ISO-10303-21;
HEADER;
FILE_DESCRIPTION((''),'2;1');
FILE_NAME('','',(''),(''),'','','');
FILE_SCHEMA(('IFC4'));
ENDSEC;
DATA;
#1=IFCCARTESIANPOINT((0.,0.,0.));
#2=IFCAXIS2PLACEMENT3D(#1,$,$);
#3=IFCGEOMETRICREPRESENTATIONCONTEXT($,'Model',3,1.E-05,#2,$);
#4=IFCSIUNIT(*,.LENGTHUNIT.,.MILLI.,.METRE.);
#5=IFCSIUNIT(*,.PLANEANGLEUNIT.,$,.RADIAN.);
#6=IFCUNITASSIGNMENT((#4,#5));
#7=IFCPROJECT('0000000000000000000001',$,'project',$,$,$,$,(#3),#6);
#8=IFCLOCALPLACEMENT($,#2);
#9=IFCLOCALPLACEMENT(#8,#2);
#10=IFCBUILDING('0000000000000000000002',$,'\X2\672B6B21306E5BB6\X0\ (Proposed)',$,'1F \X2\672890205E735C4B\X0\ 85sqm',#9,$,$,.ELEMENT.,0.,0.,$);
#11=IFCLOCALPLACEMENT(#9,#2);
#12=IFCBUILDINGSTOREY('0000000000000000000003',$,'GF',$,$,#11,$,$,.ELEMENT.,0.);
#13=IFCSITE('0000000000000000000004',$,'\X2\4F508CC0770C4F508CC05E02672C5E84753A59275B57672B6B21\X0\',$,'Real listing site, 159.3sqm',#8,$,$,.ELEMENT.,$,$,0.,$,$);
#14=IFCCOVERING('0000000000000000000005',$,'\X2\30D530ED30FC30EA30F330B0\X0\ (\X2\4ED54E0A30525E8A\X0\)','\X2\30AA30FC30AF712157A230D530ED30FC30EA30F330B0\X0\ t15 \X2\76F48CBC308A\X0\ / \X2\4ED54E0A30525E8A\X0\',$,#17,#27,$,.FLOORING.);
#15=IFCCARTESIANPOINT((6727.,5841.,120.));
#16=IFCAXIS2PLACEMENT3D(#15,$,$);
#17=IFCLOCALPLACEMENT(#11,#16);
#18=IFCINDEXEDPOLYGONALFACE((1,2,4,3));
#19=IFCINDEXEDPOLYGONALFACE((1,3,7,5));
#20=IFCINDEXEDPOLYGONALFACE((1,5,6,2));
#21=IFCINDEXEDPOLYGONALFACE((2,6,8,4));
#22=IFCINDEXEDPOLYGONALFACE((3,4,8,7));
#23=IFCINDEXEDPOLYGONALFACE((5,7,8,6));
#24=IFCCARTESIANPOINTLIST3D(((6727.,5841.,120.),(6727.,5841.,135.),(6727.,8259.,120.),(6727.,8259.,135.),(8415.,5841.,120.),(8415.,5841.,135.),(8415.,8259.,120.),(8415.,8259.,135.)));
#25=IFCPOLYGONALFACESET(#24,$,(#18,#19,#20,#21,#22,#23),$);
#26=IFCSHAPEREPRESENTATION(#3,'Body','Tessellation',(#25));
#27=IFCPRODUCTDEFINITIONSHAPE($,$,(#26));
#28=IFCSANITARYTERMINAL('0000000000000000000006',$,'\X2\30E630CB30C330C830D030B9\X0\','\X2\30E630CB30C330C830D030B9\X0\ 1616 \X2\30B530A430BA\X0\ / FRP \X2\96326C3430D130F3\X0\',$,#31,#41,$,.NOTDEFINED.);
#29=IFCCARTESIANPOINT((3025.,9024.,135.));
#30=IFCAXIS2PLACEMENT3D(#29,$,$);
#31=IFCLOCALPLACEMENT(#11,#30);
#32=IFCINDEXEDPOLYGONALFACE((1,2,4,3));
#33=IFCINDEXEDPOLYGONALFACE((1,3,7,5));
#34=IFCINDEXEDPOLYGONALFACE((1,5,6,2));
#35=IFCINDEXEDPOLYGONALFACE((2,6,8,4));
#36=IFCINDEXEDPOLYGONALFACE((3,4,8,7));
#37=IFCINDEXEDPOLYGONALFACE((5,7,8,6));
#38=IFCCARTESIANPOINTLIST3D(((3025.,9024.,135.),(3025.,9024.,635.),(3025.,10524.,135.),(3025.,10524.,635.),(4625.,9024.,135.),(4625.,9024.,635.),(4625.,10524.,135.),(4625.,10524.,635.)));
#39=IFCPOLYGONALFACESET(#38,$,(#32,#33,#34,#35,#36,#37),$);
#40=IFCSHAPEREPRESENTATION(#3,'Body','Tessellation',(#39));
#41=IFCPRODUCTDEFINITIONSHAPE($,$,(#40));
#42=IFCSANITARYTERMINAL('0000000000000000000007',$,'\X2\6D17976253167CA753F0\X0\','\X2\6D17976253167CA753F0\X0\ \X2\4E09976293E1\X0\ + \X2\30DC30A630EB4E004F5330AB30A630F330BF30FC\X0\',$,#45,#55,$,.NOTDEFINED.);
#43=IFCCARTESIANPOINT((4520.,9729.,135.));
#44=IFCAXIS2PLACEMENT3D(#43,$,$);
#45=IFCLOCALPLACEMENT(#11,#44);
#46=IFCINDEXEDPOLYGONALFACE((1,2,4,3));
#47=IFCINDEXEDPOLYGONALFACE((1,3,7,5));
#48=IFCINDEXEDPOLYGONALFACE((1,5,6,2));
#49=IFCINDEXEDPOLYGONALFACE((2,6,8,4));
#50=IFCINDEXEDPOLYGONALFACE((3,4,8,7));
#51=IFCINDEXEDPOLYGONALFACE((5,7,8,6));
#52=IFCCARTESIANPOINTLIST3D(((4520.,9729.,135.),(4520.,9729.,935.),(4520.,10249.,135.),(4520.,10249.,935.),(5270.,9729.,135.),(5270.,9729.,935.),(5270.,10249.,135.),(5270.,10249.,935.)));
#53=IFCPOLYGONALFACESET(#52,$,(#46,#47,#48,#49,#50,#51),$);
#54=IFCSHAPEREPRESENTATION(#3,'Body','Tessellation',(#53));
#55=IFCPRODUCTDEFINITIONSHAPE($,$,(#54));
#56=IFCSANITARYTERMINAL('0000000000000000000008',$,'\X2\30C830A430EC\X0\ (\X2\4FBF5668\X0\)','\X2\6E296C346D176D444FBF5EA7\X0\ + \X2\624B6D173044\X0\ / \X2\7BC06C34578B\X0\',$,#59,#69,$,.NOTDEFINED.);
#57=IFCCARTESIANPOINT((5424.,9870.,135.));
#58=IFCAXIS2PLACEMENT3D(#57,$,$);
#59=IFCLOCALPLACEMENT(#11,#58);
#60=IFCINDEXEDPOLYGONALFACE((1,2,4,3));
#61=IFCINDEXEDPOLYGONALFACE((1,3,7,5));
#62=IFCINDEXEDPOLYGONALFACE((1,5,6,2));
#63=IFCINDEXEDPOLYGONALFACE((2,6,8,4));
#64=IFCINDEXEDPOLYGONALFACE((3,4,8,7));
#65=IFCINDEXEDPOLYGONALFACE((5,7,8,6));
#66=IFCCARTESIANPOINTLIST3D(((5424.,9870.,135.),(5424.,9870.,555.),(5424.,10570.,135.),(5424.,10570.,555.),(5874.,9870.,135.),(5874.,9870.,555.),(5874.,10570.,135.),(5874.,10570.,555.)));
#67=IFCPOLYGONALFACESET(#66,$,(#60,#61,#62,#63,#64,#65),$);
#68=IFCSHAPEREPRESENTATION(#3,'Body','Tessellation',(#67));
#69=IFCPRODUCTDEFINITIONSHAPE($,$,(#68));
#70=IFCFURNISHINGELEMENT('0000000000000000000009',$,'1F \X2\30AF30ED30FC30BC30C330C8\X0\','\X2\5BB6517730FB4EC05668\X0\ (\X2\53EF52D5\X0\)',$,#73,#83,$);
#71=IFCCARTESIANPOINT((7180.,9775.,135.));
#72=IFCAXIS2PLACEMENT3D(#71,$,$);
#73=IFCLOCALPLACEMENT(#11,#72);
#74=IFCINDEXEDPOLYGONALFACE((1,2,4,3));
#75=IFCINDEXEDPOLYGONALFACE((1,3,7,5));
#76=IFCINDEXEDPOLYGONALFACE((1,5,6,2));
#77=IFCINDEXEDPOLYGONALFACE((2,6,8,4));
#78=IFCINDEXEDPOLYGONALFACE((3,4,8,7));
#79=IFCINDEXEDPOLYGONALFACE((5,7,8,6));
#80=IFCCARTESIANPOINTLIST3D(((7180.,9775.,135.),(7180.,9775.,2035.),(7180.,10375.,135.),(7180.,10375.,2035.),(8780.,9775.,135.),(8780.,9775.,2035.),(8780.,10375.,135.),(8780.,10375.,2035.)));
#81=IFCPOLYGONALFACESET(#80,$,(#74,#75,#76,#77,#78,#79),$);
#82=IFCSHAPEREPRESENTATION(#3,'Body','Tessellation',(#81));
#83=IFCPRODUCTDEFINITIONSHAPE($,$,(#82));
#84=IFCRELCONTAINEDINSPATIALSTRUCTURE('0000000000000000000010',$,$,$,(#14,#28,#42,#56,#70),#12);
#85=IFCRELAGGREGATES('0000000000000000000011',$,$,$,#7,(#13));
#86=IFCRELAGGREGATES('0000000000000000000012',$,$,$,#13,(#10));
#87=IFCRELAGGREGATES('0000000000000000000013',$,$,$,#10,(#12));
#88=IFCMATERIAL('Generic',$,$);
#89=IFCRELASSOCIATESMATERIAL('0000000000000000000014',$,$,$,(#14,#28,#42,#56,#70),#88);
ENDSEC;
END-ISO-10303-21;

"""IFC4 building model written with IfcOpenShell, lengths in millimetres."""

from ifc_helpers import new_model, si_unit, frame, frame_2d, origin, place, context, project, spatial, rectangle, extrude, material, element, save


model = new_model("IFC4")

# Units and contexts
model_context = context("Model", 3, precision=1e-05, world=origin())
ifc_project = project(units=[si_unit("LENGTHUNIT", "METRE", prefix="MILLI"), si_unit("PLANEANGLEUNIT", "RADIAN")], contexts=[model_context])

# Site, building, storey
site_placement = place(None, origin())
site = spatial("IfcSite", under=ifc_project, at=site_placement, Name="佐賀県佐賀市本庄町大字末次", ObjectType="Real listing site, 159.3sqm", CompositionType="ELEMENT", RefElevation=0.0)
building_placement = place(site_placement, origin())
building = spatial("IfcBuilding", under=site, at=building_placement, Name="末次の家 (Proposed)", ObjectType="1F 木造平屋 85sqm", CompositionType="ELEMENT", ElevationOfRefHeight=0.0, ElevationOfTerrain=0.0)
storey_placement = place(building_placement, origin())
storey = spatial("IfcBuildingStorey", under=building, at=storey_placement, Name="GF", CompositionType="ELEMENT", Elevation=0.0)

# Covering
ifc_material_1 = material(Name="Generic")
covering_1_placement = place(storey_placement, frame((6727.0, 5841.0, 120.0)))
element("IfcCovering", 1, at=covering_1_placement, inside=storey, material=ifc_material_1, Name="フローリング (仕上げ床)", Description="オーク無垢フローリング t15 直貼り / 仕上げ床", PredefinedType="FLOORING", context=model_context, shape_type="SweptSolid", body=[
    extrude(rectangle(XDim=1688.0, YDim=2418.0, at=frame_2d((844.0, 1209.0))), frame((6727.0, 5841.0, 120.0)), (0.0, 0.0, 1.0), 15.0),
])

# Sanitary terminals
sanitary_terminal_1_placement = place(storey_placement, frame((3025.0, 9024.0, 135.0)))
element("IfcSanitaryTerminal", 2, at=sanitary_terminal_1_placement, inside=storey, material=ifc_material_1, Name="ユニットバス", Description="ユニットバス 1616 サイズ / FRP 防水パン", PredefinedType="NOTDEFINED", context=model_context, shape_type="SweptSolid", body=[
    extrude(rectangle(XDim=1600.0, YDim=1500.0, at=frame_2d((800.0, 750.0))), frame((3025.0, 9024.0, 135.0)), (0.0, 0.0, 1.0), 500.0),
])
sanitary_terminal_2_placement = place(storey_placement, frame((4520.0, 9729.0, 135.0)))
element("IfcSanitaryTerminal", 3, at=sanitary_terminal_2_placement, inside=storey, material=ifc_material_1, Name="洗面化粧台", Description="洗面化粧台 三面鏡 + ボウル一体カウンター", PredefinedType="NOTDEFINED", context=model_context, shape_type="SweptSolid", body=[
    extrude(rectangle(XDim=750.0, YDim=520.0, at=frame_2d((375.0, 260.0))), frame((4520.0, 9729.0, 135.0)), (0.0, 0.0, 1.0), 800.0),
])
sanitary_terminal_3_placement = place(storey_placement, frame((5424.0, 9870.0, 135.0)))
element("IfcSanitaryTerminal", 4, at=sanitary_terminal_3_placement, inside=storey, material=ifc_material_1, Name="トイレ (便器)", Description="温水洗浄便座 + 手洗い / 節水型", PredefinedType="NOTDEFINED", context=model_context, shape_type="SweptSolid", body=[
    extrude(rectangle(XDim=450.0, YDim=700.0, at=frame_2d((225.0, 350.0))), frame((5424.0, 9870.0, 135.0)), (0.0, 0.0, 1.0), 420.0),
])

# Furnishing element
furnishing_placement = place(storey_placement, frame((7180.0, 9775.0, 135.0)))
element("IfcFurnishingElement", 5, at=furnishing_placement, inside=storey, material=ifc_material_1, Name="1F クローゼット", Description="家具・什器 (可動)", context=model_context, shape_type="SweptSolid", body=[
    extrude(rectangle(XDim=1600.0, YDim=600.0, at=frame_2d((800.0, 300.0))), frame((7180.0, 9775.0, 135.0)), (0.0, 0.0, 1.0), 1900.0),
])

save(model, "model.ifc")
